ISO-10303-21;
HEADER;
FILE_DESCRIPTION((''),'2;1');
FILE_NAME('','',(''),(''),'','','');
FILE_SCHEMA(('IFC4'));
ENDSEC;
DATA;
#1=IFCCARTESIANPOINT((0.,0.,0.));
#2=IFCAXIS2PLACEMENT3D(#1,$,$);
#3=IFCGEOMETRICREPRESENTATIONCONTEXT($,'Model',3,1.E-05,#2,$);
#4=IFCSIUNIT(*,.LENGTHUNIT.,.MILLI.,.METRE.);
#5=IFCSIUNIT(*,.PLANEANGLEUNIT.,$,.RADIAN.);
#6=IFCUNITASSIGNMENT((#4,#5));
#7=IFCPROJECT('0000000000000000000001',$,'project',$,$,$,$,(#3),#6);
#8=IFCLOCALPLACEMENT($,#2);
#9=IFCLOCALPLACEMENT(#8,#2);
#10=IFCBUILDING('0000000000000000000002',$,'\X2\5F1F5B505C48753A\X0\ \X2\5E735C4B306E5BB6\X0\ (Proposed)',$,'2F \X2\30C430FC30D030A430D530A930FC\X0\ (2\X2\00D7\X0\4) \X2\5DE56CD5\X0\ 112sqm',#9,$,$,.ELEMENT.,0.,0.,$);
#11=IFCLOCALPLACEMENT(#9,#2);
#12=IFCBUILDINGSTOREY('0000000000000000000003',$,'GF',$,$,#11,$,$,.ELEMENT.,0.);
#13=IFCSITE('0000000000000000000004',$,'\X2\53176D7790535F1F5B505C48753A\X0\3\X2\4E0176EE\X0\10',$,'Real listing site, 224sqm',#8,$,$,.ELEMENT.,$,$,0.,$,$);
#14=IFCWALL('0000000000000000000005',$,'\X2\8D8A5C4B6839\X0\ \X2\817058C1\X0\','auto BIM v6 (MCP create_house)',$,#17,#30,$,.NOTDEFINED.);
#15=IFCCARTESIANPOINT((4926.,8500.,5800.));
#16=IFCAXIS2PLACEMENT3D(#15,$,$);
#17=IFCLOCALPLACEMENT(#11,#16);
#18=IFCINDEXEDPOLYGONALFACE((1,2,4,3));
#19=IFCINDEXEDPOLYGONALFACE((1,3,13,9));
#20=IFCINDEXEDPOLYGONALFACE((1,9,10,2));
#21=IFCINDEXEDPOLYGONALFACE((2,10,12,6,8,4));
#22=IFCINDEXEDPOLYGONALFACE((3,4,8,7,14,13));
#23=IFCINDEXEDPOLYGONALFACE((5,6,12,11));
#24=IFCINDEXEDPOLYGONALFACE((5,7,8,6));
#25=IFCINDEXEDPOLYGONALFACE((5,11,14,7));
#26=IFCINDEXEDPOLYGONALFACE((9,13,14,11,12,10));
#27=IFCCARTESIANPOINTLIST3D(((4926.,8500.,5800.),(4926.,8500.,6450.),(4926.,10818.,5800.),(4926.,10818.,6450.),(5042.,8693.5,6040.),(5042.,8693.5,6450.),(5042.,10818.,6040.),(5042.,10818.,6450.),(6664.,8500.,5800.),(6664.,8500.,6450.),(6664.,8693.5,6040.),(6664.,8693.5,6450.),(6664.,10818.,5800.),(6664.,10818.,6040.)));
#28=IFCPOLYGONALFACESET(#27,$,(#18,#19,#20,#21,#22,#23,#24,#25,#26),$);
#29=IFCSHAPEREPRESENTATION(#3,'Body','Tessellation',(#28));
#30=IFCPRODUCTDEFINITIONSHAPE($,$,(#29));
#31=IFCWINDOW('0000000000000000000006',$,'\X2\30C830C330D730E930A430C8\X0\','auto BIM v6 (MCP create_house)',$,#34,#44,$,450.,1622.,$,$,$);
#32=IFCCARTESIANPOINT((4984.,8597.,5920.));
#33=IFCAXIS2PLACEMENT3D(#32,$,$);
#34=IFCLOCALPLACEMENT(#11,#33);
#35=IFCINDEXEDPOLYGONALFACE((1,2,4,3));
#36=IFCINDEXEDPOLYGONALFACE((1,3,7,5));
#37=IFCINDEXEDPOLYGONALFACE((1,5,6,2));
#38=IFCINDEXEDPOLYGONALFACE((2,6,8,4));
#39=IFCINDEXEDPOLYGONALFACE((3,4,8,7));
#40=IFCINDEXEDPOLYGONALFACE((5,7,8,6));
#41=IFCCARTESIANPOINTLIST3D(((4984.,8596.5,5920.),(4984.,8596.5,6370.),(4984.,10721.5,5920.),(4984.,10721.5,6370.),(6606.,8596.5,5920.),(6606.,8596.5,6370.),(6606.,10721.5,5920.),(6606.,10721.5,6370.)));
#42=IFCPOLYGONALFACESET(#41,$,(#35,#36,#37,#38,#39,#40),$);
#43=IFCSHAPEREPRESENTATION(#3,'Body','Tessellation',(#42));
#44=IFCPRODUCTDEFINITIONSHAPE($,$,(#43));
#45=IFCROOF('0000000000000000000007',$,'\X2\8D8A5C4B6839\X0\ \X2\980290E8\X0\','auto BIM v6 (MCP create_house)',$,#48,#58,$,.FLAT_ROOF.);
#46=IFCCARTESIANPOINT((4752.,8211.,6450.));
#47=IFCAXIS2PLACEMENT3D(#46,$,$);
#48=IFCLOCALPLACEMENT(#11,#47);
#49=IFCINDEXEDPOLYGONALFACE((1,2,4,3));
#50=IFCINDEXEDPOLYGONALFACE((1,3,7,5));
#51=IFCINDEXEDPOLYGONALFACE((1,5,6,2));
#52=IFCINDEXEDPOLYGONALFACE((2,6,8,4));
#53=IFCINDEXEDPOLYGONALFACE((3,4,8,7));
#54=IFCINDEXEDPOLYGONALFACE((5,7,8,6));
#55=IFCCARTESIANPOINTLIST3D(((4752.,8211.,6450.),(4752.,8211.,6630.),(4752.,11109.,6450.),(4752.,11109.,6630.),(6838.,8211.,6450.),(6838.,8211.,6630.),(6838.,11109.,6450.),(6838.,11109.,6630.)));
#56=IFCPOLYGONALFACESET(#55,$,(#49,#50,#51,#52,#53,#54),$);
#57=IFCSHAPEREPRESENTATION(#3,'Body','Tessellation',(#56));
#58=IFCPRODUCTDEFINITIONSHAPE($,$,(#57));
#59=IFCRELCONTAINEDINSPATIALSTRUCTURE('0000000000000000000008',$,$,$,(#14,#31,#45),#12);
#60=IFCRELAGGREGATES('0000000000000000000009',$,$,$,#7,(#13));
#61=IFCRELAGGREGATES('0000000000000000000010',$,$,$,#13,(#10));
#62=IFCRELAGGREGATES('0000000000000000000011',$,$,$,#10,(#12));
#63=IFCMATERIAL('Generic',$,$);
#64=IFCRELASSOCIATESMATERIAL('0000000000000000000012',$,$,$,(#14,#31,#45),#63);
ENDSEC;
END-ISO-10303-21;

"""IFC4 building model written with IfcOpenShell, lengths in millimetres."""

from ifc_helpers import new_model, si_unit, frame, frame_2d, origin, place, context, project, spatial, rectangle, extrude, material, element, fill, save


model = new_model("IFC4")

# Units and contexts
model_context = context("Model", 3, precision=1e-05, world=origin())
ifc_project = project(units=[si_unit("LENGTHUNIT", "METRE", prefix="MILLI"), si_unit("PLANEANGLEUNIT", "RADIAN")], contexts=[model_context])

# Site, building, storey
site_placement = place(None, origin())
site = spatial("IfcSite", under=ifc_project, at=site_placement, Name="北海道弟子屈町3丁目10", ObjectType="Real listing site, 224sqm", CompositionType="ELEMENT", RefElevation=0.0)
building_placement = place(site_placement, origin())
building = spatial("IfcBuilding", under=site, at=building_placement, Name="弟子屈町 平屋の家 (Proposed)", ObjectType="2F ツーバイフォー (2×4) 工法 112sqm", CompositionType="ELEMENT", ElevationOfRefHeight=0.0, ElevationOfTerrain=0.0)
storey_placement = place(building_placement, origin())
storey = spatial("IfcBuildingStorey", under=building, at=storey_placement, Name="GF", CompositionType="ELEMENT", Elevation=0.0)

# Shared definitions
ifc_material = material(Name="Generic")

# Wall, opening, window
wall_1_placement = place(storey_placement, frame((4926.0, 8500.0, 5800.0)))
wall_1 = element("IfcWall", 1, at=wall_1_placement, inside=storey, material=ifc_material, Name="越屋根 腰壁", Description="auto BIM v6 (MCP create_house)", PredefinedType="NOTDEFINED", context=model_context, shape_type="SweptSolid", body=[
    extrude(rectangle(XDim=1738.0, YDim=2318.0, at=frame_2d((869.0, 1159.0))), frame((4926.0, 8500.0, 5800.0)), (0.0, 0.0, 1.0), 650.0),
])
opening_1_placement = place(storey_placement, frame((4984.0, 8597.0, 5920.0)))
opening_1 = element("IfcOpeningElement", 2, at=opening_1_placement, cuts=wall_1, PredefinedType="NOTDEFINED", context=model_context, shape_type="SweptSolid", body=[
    extrude(rectangle(XDim=1622.0, YDim=2125.0, at=frame_2d((811.0, 1062.0))), frame((4984.0, 8597.0, 5920.0)), (0.0, 0.0, 1.0), 450.0),
])
window_1_placement = place(storey_placement, frame((4984.0, 8597.0, 5920.0)))
window_1 = element("IfcWindow", 3, at=window_1_placement, inside=storey, material=ifc_material, Name="トップライト", Description="auto BIM v6 (MCP create_house)", OverallHeight=450.0, OverallWidth=1622.0, context=model_context, shape_type="SweptSolid", body=[
    extrude(rectangle(XDim=1622.0, YDim=2125.0, at=frame_2d((811.0, 1062.0))), frame((4984.0, 8597.0, 5920.0)), (0.0, 0.0, 1.0), 450.0),
])
fill(opening_1, window_1)

# Roof
roof_placement = place(storey_placement, frame((4752.0, 8211.0, 6450.0)))
element("IfcRoof", 4, at=roof_placement, inside=storey, material=ifc_material, Name="越屋根 頂部", Description="auto BIM v6 (MCP create_house)", PredefinedType="FLAT_ROOF", context=model_context, shape_type="SweptSolid", body=[
    extrude(rectangle(XDim=2086.0, YDim=2898.0, at=frame_2d((1043.0, 1449.0))), frame((4752.0, 8211.0, 6450.0)), (0.0, 0.0, 1.0), 180.0),
])

save(model, "model.ifc")
